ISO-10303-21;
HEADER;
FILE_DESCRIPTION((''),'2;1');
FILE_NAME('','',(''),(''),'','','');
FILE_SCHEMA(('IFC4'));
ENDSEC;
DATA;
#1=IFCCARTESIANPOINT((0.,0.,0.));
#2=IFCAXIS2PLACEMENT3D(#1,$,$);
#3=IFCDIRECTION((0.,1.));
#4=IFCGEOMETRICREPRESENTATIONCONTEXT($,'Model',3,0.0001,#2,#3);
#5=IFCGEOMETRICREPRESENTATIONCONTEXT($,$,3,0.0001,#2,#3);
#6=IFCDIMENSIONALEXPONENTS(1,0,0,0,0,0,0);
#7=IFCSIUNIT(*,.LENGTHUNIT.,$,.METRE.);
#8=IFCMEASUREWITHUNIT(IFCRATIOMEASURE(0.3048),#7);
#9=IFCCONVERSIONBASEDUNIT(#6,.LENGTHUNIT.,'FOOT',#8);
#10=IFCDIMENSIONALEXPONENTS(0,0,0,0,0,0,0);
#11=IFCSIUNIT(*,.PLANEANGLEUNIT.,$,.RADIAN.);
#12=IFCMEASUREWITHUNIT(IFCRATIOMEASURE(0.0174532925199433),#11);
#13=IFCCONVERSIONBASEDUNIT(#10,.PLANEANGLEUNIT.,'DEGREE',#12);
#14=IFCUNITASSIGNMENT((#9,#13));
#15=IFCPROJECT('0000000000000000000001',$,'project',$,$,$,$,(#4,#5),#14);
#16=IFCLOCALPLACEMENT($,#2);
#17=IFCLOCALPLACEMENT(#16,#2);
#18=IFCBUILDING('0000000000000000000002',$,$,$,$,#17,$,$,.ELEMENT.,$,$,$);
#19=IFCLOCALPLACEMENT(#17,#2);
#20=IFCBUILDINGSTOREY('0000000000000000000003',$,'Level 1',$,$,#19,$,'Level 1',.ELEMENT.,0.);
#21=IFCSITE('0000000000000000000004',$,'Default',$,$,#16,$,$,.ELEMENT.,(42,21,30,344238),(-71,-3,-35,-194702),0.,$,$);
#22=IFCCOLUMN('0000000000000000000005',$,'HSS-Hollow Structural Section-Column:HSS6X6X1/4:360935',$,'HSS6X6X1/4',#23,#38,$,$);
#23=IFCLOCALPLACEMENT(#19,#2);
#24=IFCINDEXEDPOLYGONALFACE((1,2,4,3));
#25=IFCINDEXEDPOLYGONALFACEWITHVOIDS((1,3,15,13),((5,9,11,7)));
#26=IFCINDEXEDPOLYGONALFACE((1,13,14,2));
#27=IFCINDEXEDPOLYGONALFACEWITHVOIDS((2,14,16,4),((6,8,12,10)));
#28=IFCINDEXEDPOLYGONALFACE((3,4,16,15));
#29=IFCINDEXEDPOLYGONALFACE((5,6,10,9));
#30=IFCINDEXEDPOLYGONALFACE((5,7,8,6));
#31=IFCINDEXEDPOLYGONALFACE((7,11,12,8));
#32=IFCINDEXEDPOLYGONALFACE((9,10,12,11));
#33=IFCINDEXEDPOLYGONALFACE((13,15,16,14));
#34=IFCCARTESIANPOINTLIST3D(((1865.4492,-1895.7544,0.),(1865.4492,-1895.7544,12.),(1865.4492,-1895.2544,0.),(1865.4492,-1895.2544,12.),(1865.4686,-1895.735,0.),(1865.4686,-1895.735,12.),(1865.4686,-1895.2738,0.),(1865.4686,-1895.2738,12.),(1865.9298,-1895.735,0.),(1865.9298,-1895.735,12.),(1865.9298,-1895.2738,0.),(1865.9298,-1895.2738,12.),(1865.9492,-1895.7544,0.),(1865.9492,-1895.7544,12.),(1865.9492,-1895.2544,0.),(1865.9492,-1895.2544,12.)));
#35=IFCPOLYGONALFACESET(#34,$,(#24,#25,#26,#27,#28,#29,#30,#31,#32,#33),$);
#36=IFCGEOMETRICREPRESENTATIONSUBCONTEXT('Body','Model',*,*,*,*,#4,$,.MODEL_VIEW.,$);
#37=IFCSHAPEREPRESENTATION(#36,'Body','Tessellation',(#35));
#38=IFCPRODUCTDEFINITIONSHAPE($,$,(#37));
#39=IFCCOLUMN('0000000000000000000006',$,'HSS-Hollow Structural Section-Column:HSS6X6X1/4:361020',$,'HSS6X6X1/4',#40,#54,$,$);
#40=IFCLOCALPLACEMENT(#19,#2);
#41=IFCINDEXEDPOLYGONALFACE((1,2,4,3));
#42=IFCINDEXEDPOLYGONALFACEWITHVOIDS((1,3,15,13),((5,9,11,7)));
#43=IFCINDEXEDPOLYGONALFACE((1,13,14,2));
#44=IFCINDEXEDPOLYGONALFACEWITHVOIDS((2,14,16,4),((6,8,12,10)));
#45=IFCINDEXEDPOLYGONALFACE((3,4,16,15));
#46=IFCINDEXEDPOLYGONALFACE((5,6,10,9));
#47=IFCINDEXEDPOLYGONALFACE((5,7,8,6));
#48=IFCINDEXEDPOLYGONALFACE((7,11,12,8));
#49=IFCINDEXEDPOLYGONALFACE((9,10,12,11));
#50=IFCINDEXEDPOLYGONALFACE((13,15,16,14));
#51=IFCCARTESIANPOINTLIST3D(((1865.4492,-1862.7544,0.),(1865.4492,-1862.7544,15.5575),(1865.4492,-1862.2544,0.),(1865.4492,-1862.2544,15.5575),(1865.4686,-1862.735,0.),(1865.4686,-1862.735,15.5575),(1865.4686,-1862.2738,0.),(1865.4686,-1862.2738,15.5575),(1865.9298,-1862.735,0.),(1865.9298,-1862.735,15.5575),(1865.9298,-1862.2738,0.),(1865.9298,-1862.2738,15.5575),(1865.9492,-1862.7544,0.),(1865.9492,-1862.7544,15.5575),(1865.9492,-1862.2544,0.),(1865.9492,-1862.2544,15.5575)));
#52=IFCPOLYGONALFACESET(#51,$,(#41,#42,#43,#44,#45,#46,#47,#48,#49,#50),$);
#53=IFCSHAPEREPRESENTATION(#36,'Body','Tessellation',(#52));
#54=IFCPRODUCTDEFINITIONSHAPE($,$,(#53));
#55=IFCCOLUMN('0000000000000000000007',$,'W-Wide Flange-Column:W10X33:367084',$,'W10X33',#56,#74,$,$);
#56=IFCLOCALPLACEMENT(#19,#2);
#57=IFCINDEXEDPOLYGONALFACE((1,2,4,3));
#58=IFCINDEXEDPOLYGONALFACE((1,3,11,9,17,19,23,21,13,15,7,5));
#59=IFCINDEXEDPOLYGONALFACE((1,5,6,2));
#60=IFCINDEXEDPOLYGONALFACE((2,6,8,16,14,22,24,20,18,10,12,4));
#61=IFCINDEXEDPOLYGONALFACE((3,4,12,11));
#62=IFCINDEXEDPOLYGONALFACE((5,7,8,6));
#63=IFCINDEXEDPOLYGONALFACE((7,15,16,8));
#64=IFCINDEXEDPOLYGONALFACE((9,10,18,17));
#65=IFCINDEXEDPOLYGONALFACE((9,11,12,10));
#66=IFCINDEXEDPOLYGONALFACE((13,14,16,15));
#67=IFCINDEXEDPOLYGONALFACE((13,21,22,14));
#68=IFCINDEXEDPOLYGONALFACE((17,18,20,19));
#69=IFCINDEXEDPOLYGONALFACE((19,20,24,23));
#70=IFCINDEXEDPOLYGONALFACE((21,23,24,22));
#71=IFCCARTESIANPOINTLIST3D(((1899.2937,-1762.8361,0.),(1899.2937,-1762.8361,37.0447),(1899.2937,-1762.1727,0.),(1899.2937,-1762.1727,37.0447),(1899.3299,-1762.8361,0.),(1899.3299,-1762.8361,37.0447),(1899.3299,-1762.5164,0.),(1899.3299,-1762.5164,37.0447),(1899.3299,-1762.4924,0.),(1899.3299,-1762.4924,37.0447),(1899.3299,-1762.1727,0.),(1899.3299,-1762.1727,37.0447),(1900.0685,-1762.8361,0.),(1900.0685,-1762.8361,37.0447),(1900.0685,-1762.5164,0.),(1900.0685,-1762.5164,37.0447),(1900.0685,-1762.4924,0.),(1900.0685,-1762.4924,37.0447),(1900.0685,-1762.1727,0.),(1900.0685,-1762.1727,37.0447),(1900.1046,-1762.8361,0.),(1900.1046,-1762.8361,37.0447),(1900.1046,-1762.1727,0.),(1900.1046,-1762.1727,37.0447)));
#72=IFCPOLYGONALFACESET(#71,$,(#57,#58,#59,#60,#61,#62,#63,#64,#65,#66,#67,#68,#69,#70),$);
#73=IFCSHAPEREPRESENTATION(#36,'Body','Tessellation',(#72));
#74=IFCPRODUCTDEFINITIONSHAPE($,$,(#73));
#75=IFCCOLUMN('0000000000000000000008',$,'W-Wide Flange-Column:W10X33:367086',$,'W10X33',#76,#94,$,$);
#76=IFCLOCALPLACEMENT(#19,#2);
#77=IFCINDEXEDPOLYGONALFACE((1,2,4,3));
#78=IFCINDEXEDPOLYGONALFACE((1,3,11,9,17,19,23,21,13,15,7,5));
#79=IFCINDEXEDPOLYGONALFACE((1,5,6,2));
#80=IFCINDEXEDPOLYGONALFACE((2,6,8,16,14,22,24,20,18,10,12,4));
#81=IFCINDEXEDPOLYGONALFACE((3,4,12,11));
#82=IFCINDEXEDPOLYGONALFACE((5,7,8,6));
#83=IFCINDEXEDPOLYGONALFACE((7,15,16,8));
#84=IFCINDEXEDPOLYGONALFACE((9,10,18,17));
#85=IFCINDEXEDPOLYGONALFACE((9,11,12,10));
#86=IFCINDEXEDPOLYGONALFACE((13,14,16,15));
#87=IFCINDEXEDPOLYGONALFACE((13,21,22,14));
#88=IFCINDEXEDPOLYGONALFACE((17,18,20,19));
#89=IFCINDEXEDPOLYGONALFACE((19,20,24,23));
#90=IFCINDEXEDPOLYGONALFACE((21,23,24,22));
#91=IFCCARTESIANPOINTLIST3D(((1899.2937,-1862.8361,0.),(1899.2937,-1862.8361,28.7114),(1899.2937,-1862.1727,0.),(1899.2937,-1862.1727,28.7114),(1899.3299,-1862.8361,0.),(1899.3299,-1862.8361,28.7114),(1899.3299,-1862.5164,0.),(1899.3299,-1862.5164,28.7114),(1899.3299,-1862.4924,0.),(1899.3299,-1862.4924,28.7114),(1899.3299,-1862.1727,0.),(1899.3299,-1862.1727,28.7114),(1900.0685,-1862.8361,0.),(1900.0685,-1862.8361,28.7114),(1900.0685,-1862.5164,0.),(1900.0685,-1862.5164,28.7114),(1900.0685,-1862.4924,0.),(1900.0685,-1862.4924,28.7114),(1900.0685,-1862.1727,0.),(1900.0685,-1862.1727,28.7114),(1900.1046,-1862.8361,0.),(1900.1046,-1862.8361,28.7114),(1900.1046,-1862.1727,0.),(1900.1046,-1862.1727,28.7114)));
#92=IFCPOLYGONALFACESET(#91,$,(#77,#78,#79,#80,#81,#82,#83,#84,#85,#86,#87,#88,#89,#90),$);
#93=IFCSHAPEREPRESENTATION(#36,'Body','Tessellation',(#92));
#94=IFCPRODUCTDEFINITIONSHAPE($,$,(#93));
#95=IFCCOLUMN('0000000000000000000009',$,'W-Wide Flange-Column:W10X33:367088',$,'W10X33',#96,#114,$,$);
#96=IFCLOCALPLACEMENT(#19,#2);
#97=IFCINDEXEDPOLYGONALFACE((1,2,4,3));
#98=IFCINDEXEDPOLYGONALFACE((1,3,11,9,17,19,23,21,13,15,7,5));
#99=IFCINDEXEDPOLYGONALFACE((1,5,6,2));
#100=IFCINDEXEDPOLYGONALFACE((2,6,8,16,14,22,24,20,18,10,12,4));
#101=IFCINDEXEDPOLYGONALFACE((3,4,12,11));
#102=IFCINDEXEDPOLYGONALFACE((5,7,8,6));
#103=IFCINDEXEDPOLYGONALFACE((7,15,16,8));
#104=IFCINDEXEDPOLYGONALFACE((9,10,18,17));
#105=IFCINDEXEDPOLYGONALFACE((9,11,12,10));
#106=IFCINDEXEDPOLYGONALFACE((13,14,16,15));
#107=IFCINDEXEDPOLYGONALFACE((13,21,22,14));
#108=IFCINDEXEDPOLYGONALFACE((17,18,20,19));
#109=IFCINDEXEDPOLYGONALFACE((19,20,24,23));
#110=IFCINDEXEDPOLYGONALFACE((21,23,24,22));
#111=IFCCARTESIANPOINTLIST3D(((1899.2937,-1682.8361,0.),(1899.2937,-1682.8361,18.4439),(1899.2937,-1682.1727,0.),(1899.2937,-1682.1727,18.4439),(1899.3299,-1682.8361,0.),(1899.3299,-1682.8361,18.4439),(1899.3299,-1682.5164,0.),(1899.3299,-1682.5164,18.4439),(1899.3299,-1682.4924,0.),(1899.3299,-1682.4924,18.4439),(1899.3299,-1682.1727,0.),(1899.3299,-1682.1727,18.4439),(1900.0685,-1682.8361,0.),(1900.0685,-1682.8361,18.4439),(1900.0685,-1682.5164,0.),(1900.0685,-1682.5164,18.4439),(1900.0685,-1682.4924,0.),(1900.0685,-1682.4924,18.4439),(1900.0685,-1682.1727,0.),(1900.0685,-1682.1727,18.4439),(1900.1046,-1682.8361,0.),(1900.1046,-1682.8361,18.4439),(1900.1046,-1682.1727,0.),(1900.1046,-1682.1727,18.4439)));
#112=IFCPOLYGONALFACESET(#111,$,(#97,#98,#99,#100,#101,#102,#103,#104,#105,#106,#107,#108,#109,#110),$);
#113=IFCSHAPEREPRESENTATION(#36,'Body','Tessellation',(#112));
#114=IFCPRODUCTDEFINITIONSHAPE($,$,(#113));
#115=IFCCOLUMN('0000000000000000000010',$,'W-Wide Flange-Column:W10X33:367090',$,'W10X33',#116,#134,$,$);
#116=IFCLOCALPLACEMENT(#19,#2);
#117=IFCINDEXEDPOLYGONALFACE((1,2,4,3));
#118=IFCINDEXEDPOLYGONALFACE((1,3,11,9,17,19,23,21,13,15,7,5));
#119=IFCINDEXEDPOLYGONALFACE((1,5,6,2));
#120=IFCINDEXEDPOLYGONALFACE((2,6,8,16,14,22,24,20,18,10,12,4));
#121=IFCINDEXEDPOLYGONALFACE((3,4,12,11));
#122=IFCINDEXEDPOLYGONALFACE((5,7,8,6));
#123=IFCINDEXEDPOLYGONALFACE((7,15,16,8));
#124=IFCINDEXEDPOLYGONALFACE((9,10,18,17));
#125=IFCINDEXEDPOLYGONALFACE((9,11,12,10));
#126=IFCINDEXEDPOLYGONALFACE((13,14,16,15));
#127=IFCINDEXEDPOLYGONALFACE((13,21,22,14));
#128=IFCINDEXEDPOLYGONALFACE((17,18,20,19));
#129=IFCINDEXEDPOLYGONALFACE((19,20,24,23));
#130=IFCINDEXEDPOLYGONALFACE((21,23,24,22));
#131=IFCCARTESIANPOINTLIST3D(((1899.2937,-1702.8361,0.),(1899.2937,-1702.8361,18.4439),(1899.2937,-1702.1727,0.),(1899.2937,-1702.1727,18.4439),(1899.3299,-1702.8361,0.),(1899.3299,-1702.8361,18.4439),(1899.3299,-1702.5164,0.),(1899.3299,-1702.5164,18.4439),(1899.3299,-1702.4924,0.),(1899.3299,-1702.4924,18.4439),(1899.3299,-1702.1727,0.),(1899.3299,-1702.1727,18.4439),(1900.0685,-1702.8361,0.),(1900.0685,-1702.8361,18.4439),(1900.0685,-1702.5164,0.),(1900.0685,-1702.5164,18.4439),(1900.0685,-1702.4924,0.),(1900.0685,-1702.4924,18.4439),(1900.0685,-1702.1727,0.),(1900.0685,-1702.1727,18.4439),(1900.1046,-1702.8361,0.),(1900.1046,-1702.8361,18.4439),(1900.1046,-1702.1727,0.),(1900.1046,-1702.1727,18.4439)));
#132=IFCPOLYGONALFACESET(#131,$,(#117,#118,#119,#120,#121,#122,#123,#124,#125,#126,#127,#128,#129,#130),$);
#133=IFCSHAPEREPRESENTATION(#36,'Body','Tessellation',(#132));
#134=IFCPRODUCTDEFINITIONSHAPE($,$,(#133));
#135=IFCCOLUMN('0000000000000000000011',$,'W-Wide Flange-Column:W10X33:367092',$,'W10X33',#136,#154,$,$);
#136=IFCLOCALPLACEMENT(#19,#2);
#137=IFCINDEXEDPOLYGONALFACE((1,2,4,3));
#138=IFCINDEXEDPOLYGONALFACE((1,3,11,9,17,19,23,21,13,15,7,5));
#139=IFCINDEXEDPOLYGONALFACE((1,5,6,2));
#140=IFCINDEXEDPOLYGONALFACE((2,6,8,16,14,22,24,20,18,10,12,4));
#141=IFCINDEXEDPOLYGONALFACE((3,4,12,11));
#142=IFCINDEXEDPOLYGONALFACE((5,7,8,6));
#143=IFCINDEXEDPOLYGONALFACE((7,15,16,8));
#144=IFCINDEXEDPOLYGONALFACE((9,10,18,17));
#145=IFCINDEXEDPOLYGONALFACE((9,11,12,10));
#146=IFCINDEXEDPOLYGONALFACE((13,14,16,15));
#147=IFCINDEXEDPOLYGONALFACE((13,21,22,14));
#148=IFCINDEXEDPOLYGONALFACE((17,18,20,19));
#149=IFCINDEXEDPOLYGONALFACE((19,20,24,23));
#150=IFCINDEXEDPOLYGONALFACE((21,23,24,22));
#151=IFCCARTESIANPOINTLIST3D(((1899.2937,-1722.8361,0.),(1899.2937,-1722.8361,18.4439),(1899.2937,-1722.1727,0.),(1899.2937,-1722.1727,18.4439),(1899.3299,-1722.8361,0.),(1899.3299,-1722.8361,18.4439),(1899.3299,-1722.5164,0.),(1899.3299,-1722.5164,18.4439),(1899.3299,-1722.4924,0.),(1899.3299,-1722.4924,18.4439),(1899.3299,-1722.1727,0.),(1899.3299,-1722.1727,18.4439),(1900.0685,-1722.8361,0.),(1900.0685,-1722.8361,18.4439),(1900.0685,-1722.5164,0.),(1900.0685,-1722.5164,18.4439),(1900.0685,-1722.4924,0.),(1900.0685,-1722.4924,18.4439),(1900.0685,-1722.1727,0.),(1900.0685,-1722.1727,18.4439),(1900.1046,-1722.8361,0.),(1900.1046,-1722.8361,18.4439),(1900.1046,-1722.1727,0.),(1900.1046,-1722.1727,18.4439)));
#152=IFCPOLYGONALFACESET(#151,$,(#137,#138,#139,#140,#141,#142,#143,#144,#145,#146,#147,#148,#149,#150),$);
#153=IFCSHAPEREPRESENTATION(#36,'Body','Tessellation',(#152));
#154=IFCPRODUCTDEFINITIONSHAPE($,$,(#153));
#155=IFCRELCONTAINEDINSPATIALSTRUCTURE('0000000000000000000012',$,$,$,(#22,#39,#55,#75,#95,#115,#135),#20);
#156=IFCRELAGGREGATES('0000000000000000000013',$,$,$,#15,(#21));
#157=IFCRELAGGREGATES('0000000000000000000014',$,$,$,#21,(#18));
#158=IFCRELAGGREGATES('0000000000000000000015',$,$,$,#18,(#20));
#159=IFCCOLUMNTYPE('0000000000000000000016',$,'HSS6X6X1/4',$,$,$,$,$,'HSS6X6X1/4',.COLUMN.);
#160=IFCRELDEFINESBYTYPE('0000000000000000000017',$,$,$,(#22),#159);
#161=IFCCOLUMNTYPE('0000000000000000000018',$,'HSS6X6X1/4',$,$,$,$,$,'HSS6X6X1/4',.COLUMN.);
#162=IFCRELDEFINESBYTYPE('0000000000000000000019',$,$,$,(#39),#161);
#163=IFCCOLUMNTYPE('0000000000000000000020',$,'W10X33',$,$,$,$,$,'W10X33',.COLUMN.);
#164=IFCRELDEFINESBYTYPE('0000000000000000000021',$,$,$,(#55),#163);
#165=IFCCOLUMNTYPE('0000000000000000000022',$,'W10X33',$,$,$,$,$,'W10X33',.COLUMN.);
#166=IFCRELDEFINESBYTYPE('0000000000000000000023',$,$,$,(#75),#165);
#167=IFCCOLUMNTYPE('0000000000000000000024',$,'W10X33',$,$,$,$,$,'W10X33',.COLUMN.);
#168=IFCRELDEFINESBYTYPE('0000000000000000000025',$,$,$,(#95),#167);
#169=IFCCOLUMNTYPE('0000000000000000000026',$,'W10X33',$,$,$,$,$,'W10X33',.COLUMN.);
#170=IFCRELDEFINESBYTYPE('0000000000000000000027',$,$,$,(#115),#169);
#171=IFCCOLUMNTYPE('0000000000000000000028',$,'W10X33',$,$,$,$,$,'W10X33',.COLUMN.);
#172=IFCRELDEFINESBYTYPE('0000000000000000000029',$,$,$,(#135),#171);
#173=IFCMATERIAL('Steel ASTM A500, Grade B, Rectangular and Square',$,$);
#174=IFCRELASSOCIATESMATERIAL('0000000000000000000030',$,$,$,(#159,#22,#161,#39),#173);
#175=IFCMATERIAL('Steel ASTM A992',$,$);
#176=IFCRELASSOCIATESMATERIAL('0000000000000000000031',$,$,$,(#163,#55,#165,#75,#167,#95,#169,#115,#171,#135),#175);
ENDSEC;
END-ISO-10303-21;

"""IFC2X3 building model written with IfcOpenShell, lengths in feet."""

from ifc_helpers import new_model, entity, si_unit, converted_unit, direction, frame, frame_2d, origin, place, context, subcontext, project, spatial, polyline, i_section, outline, extrude, source, transform, mapped, material, type_object, type_shapes, element, save


model = new_model("IFC2X3")

# Units and contexts
model_context = context("Model", 3, precision=0.0001, world=origin(), true_north=direction((0.0, 1.0)))
context_of_model = context(None, 3, precision=0.0001, world=origin(), true_north=direction((0.0, 1.0)))
body_context = subcontext(model_context, "Body", "Model", "MODEL_VIEW")
ifc_project = project(units=[converted_unit("LENGTHUNIT", "FOOT", entity("IfcRatioMeasure", 0.3048), si_unit("LENGTHUNIT", "METRE"), dimensions=[1, 0, 0, 0, 0, 0, 0]), converted_unit("PLANEANGLEUNIT", "DEGREE", entity("IfcRatioMeasure", 0.0174532925199433), si_unit("PLANEANGLEUNIT", "RADIAN"), dimensions=[0, 0, 0, 0, 0, 0, 0])], contexts=[model_context, context_of_model])

# Site, building, storey
site_placement = place(None, origin())
site = spatial("IfcSite", under=ifc_project, at=site_placement, Name="Default", CompositionType="ELEMENT", RefLatitude=(42, 21, 30, 344238), RefLongitude=(-71, -3, -35, -194702), RefElevation=0.0)
building_placement = place(site_placement, origin())
building = spatial("IfcBuilding", under=site, at=building_placement, CompositionType="ELEMENT")
storey_placement = place(building_placement, origin())
storey = spatial("IfcBuildingStorey", under=building, at=storey_placement, Name="Level 1", LongName="Level 1", CompositionType="ELEMENT", Elevation=0.0)

# Columns
ifc_material_1 = material(Name="Steel ASTM A500, Grade B, Rectangular and Square")
column_type_1 = type_object("IfcColumnType", Name="HSS6X6X1/4", ElementType="HSS6X6X1/4", PredefinedType="COLUMN", material=ifc_material_1)
shared_shape_1 = source(origin(), body_context, "Body", "SweptSolid", [
    extrude(outline(polyline([(-0.25, -0.25), (0.25, -0.25), (0.25, 0.25), (-0.25, 0.25), (-0.25, -0.25)]), holes=[polyline([(-0.2306, -0.2306), (-0.2306, 0.2306), (0.2306, 0.2306), (0.2306, -0.2306), (-0.2306, -0.2306)])]), frame((0.0, 0.0, 0.0), z_axis=(0.0, 0.0, 1.0), x_axis=(-1.0, 0.0, 0.0)), (0.0, 0.0, 1.0), 12.0),
])
type_shapes(column_type_1, [shared_shape_1])
column_1_placement = place(storey_placement, frame((1865.6992, -1895.5044, 0.0), z_axis=(0.0, 0.0, 1.0), x_axis=(-1.0, 0.0, 0.0)))
element("IfcColumn", 1, at=column_1_placement, inside=storey, type_object=column_type_1, material=ifc_material_1, Name="HSS-Hollow Structural Section-Column:HSS6X6X1/4:360935", ObjectType="HSS6X6X1/4", context=body_context, shape_type="MappedRepresentation", body=[
    mapped(shared_shape_1, transform((0.0, 0.0, 0.0), scale=1.0)),
])
column_type_2 = type_object("IfcColumnType", Name="HSS6X6X1/4", ElementType="HSS6X6X1/4", PredefinedType="COLUMN", material=ifc_material_1)
shared_shape_2 = source(origin(), body_context, "Body", "SweptSolid", [
    extrude(outline(polyline([(-0.25, -0.25), (0.25, -0.25), (0.25, 0.25), (-0.25, 0.25), (-0.25, -0.25)]), holes=[polyline([(-0.2306, -0.2306), (-0.2306, 0.2306), (0.2306, 0.2306), (0.2306, -0.2306), (-0.2306, -0.2306)])]), frame((0.25, 0.25, 0.0), z_axis=(0.0, 0.0, 1.0), x_axis=(0.0, 1.0, 0.0)), (0.0, 0.0, 1.0), 15.5575),
])
type_shapes(column_type_2, [shared_shape_2])
column_2_placement = place(storey_placement, frame((1865.4492, -1862.7544, 0.0)))
element("IfcColumn", 2, at=column_2_placement, inside=storey, type_object=column_type_2, material=ifc_material_1, Name="HSS-Hollow Structural Section-Column:HSS6X6X1/4:361020", ObjectType="HSS6X6X1/4", context=body_context, shape_type="MappedRepresentation", body=[
    mapped(shared_shape_2, transform((0.0, 0.0, 0.0), scale=1.0)),
])
ifc_material_2 = material(Name="Steel ASTM A992")
column_type_3 = type_object("IfcColumnType", Name="W10X33", ElementType="W10X33", PredefinedType="COLUMN", material=ifc_material_2)
shared_shape_3 = source(origin(), body_context, "Body", "SweptSolid", [
    extrude(i_section(OverallWidth=0.6634, OverallDepth=0.8109, WebThickness=0.0241, FlangeThickness=0.0361, at=frame_2d((0.0, 0.0), x_axis=(1.0, 0.0))), frame((0.4054, 0.3317, 0.0), z_axis=(0.0, 0.0, 1.0), x_axis=(0.0, 1.0, 0.0)), (0.0, 0.0, 1.0), 37.0447),
])
type_shapes(column_type_3, [shared_shape_3])
column_3_placement = place(storey_placement, frame((1899.2937, -1762.8361, 0.0)))
element("IfcColumn", 3, at=column_3_placement, inside=storey, type_object=column_type_3, material=ifc_material_2, Name="W-Wide Flange-Column:W10X33:367084", ObjectType="W10X33", context=body_context, shape_type="MappedRepresentation", body=[
    mapped(shared_shape_3, transform((0.0, 0.0, 0.0), scale=1.0)),
])
column_type_4 = type_object("IfcColumnType", Name="W10X33", ElementType="W10X33", PredefinedType="COLUMN", material=ifc_material_2)
shared_shape_4 = source(origin(), body_context, "Body", "SweptSolid", [
    extrude(i_section(OverallWidth=0.6634, OverallDepth=0.8109, WebThickness=0.0241, FlangeThickness=0.0361, at=frame_2d((0.0, 0.0), x_axis=(1.0, 0.0))), frame((0.4054, 0.3317, 0.0), z_axis=(0.0, 0.0, 1.0), x_axis=(0.0, 1.0, 0.0)), (0.0, 0.0, 1.0), 28.7114),
])
type_shapes(column_type_4, [shared_shape_4])
column_4_placement = place(storey_placement, frame((1899.2937, -1862.8361, 0.0)))
element("IfcColumn", 4, at=column_4_placement, inside=storey, type_object=column_type_4, material=ifc_material_2, Name="W-Wide Flange-Column:W10X33:367086", ObjectType="W10X33", context=body_context, shape_type="MappedRepresentation", body=[
    mapped(shared_shape_4, transform((0.0, 0.0, 0.0), scale=1.0)),
])
column_type_5 = type_object("IfcColumnType", Name="W10X33", ElementType="W10X33", PredefinedType="COLUMN", material=ifc_material_2)
shared_shape_5 = source(origin(), body_context, "Body", "SweptSolid", [
    extrude(i_section(OverallWidth=0.6634, OverallDepth=0.8109, WebThickness=0.0241, FlangeThickness=0.0361, at=frame_2d((0.0, 0.0), x_axis=(1.0, 0.0))), frame((0.4054, 0.3317, 0.0), z_axis=(0.0, 0.0, 1.0), x_axis=(0.0, 1.0, 0.0)), (0.0, 0.0, 1.0), 18.4439),
])
type_shapes(column_type_5, [shared_shape_5])
column_5_placement = place(storey_placement, frame((1899.2937, -1682.8361, 0.0)))
element("IfcColumn", 5, at=column_5_placement, inside=storey, type_object=column_type_5, material=ifc_material_2, Name="W-Wide Flange-Column:W10X33:367088", ObjectType="W10X33", context=body_context, shape_type="MappedRepresentation", body=[
    mapped(shared_shape_5, transform((0.0, 0.0, 0.0), scale=1.0)),
])
column_type_6 = type_object("IfcColumnType", Name="W10X33", ElementType="W10X33", PredefinedType="COLUMN", material=ifc_material_2)
shared_shape_6 = source(origin(), body_context, "Body", "SweptSolid", [
    extrude(i_section(OverallWidth=0.6634, OverallDepth=0.8109, WebThickness=0.0241, FlangeThickness=0.0361, at=frame_2d((0.0, 0.0), x_axis=(1.0, 0.0))), frame((0.4054, 0.3317, 0.0), z_axis=(0.0, 0.0, 1.0), x_axis=(0.0, 1.0, 0.0)), (0.0, 0.0, 1.0), 18.4439),
])
type_shapes(column_type_6, [shared_shape_6])
column_6_placement = place(storey_placement, frame((1899.2937, -1702.8361, 0.0)))
element("IfcColumn", 6, at=column_6_placement, inside=storey, type_object=column_type_6, material=ifc_material_2, Name="W-Wide Flange-Column:W10X33:367090", ObjectType="W10X33", context=body_context, shape_type="MappedRepresentation", body=[
    mapped(shared_shape_6, transform((0.0, 0.0, 0.0), scale=1.0)),
])
column_type_7 = type_object("IfcColumnType", Name="W10X33", ElementType="W10X33", PredefinedType="COLUMN", material=ifc_material_2)
shared_shape_7 = source(origin(), body_context, "Body", "SweptSolid", [
    extrude(i_section(OverallWidth=0.6634, OverallDepth=0.8109, WebThickness=0.0241, FlangeThickness=0.0361, at=frame_2d((0.0, 0.0), x_axis=(1.0, 0.0))), frame((0.4054, 0.3317, 0.0), z_axis=(0.0, 0.0, 1.0), x_axis=(0.0, 1.0, 0.0)), (0.0, 0.0, 1.0), 18.4439),
])
type_shapes(column_type_7, [shared_shape_7])
column_7_placement = place(storey_placement, frame((1899.2937, -1722.8361, 0.0)))
element("IfcColumn", 7, at=column_7_placement, inside=storey, type_object=column_type_7, material=ifc_material_2, Name="W-Wide Flange-Column:W10X33:367092", ObjectType="W10X33", context=body_context, shape_type="MappedRepresentation", body=[
    mapped(shared_shape_7, transform((0.0, 0.0, 0.0), scale=1.0)),
])

save(model, "model.ifc")
